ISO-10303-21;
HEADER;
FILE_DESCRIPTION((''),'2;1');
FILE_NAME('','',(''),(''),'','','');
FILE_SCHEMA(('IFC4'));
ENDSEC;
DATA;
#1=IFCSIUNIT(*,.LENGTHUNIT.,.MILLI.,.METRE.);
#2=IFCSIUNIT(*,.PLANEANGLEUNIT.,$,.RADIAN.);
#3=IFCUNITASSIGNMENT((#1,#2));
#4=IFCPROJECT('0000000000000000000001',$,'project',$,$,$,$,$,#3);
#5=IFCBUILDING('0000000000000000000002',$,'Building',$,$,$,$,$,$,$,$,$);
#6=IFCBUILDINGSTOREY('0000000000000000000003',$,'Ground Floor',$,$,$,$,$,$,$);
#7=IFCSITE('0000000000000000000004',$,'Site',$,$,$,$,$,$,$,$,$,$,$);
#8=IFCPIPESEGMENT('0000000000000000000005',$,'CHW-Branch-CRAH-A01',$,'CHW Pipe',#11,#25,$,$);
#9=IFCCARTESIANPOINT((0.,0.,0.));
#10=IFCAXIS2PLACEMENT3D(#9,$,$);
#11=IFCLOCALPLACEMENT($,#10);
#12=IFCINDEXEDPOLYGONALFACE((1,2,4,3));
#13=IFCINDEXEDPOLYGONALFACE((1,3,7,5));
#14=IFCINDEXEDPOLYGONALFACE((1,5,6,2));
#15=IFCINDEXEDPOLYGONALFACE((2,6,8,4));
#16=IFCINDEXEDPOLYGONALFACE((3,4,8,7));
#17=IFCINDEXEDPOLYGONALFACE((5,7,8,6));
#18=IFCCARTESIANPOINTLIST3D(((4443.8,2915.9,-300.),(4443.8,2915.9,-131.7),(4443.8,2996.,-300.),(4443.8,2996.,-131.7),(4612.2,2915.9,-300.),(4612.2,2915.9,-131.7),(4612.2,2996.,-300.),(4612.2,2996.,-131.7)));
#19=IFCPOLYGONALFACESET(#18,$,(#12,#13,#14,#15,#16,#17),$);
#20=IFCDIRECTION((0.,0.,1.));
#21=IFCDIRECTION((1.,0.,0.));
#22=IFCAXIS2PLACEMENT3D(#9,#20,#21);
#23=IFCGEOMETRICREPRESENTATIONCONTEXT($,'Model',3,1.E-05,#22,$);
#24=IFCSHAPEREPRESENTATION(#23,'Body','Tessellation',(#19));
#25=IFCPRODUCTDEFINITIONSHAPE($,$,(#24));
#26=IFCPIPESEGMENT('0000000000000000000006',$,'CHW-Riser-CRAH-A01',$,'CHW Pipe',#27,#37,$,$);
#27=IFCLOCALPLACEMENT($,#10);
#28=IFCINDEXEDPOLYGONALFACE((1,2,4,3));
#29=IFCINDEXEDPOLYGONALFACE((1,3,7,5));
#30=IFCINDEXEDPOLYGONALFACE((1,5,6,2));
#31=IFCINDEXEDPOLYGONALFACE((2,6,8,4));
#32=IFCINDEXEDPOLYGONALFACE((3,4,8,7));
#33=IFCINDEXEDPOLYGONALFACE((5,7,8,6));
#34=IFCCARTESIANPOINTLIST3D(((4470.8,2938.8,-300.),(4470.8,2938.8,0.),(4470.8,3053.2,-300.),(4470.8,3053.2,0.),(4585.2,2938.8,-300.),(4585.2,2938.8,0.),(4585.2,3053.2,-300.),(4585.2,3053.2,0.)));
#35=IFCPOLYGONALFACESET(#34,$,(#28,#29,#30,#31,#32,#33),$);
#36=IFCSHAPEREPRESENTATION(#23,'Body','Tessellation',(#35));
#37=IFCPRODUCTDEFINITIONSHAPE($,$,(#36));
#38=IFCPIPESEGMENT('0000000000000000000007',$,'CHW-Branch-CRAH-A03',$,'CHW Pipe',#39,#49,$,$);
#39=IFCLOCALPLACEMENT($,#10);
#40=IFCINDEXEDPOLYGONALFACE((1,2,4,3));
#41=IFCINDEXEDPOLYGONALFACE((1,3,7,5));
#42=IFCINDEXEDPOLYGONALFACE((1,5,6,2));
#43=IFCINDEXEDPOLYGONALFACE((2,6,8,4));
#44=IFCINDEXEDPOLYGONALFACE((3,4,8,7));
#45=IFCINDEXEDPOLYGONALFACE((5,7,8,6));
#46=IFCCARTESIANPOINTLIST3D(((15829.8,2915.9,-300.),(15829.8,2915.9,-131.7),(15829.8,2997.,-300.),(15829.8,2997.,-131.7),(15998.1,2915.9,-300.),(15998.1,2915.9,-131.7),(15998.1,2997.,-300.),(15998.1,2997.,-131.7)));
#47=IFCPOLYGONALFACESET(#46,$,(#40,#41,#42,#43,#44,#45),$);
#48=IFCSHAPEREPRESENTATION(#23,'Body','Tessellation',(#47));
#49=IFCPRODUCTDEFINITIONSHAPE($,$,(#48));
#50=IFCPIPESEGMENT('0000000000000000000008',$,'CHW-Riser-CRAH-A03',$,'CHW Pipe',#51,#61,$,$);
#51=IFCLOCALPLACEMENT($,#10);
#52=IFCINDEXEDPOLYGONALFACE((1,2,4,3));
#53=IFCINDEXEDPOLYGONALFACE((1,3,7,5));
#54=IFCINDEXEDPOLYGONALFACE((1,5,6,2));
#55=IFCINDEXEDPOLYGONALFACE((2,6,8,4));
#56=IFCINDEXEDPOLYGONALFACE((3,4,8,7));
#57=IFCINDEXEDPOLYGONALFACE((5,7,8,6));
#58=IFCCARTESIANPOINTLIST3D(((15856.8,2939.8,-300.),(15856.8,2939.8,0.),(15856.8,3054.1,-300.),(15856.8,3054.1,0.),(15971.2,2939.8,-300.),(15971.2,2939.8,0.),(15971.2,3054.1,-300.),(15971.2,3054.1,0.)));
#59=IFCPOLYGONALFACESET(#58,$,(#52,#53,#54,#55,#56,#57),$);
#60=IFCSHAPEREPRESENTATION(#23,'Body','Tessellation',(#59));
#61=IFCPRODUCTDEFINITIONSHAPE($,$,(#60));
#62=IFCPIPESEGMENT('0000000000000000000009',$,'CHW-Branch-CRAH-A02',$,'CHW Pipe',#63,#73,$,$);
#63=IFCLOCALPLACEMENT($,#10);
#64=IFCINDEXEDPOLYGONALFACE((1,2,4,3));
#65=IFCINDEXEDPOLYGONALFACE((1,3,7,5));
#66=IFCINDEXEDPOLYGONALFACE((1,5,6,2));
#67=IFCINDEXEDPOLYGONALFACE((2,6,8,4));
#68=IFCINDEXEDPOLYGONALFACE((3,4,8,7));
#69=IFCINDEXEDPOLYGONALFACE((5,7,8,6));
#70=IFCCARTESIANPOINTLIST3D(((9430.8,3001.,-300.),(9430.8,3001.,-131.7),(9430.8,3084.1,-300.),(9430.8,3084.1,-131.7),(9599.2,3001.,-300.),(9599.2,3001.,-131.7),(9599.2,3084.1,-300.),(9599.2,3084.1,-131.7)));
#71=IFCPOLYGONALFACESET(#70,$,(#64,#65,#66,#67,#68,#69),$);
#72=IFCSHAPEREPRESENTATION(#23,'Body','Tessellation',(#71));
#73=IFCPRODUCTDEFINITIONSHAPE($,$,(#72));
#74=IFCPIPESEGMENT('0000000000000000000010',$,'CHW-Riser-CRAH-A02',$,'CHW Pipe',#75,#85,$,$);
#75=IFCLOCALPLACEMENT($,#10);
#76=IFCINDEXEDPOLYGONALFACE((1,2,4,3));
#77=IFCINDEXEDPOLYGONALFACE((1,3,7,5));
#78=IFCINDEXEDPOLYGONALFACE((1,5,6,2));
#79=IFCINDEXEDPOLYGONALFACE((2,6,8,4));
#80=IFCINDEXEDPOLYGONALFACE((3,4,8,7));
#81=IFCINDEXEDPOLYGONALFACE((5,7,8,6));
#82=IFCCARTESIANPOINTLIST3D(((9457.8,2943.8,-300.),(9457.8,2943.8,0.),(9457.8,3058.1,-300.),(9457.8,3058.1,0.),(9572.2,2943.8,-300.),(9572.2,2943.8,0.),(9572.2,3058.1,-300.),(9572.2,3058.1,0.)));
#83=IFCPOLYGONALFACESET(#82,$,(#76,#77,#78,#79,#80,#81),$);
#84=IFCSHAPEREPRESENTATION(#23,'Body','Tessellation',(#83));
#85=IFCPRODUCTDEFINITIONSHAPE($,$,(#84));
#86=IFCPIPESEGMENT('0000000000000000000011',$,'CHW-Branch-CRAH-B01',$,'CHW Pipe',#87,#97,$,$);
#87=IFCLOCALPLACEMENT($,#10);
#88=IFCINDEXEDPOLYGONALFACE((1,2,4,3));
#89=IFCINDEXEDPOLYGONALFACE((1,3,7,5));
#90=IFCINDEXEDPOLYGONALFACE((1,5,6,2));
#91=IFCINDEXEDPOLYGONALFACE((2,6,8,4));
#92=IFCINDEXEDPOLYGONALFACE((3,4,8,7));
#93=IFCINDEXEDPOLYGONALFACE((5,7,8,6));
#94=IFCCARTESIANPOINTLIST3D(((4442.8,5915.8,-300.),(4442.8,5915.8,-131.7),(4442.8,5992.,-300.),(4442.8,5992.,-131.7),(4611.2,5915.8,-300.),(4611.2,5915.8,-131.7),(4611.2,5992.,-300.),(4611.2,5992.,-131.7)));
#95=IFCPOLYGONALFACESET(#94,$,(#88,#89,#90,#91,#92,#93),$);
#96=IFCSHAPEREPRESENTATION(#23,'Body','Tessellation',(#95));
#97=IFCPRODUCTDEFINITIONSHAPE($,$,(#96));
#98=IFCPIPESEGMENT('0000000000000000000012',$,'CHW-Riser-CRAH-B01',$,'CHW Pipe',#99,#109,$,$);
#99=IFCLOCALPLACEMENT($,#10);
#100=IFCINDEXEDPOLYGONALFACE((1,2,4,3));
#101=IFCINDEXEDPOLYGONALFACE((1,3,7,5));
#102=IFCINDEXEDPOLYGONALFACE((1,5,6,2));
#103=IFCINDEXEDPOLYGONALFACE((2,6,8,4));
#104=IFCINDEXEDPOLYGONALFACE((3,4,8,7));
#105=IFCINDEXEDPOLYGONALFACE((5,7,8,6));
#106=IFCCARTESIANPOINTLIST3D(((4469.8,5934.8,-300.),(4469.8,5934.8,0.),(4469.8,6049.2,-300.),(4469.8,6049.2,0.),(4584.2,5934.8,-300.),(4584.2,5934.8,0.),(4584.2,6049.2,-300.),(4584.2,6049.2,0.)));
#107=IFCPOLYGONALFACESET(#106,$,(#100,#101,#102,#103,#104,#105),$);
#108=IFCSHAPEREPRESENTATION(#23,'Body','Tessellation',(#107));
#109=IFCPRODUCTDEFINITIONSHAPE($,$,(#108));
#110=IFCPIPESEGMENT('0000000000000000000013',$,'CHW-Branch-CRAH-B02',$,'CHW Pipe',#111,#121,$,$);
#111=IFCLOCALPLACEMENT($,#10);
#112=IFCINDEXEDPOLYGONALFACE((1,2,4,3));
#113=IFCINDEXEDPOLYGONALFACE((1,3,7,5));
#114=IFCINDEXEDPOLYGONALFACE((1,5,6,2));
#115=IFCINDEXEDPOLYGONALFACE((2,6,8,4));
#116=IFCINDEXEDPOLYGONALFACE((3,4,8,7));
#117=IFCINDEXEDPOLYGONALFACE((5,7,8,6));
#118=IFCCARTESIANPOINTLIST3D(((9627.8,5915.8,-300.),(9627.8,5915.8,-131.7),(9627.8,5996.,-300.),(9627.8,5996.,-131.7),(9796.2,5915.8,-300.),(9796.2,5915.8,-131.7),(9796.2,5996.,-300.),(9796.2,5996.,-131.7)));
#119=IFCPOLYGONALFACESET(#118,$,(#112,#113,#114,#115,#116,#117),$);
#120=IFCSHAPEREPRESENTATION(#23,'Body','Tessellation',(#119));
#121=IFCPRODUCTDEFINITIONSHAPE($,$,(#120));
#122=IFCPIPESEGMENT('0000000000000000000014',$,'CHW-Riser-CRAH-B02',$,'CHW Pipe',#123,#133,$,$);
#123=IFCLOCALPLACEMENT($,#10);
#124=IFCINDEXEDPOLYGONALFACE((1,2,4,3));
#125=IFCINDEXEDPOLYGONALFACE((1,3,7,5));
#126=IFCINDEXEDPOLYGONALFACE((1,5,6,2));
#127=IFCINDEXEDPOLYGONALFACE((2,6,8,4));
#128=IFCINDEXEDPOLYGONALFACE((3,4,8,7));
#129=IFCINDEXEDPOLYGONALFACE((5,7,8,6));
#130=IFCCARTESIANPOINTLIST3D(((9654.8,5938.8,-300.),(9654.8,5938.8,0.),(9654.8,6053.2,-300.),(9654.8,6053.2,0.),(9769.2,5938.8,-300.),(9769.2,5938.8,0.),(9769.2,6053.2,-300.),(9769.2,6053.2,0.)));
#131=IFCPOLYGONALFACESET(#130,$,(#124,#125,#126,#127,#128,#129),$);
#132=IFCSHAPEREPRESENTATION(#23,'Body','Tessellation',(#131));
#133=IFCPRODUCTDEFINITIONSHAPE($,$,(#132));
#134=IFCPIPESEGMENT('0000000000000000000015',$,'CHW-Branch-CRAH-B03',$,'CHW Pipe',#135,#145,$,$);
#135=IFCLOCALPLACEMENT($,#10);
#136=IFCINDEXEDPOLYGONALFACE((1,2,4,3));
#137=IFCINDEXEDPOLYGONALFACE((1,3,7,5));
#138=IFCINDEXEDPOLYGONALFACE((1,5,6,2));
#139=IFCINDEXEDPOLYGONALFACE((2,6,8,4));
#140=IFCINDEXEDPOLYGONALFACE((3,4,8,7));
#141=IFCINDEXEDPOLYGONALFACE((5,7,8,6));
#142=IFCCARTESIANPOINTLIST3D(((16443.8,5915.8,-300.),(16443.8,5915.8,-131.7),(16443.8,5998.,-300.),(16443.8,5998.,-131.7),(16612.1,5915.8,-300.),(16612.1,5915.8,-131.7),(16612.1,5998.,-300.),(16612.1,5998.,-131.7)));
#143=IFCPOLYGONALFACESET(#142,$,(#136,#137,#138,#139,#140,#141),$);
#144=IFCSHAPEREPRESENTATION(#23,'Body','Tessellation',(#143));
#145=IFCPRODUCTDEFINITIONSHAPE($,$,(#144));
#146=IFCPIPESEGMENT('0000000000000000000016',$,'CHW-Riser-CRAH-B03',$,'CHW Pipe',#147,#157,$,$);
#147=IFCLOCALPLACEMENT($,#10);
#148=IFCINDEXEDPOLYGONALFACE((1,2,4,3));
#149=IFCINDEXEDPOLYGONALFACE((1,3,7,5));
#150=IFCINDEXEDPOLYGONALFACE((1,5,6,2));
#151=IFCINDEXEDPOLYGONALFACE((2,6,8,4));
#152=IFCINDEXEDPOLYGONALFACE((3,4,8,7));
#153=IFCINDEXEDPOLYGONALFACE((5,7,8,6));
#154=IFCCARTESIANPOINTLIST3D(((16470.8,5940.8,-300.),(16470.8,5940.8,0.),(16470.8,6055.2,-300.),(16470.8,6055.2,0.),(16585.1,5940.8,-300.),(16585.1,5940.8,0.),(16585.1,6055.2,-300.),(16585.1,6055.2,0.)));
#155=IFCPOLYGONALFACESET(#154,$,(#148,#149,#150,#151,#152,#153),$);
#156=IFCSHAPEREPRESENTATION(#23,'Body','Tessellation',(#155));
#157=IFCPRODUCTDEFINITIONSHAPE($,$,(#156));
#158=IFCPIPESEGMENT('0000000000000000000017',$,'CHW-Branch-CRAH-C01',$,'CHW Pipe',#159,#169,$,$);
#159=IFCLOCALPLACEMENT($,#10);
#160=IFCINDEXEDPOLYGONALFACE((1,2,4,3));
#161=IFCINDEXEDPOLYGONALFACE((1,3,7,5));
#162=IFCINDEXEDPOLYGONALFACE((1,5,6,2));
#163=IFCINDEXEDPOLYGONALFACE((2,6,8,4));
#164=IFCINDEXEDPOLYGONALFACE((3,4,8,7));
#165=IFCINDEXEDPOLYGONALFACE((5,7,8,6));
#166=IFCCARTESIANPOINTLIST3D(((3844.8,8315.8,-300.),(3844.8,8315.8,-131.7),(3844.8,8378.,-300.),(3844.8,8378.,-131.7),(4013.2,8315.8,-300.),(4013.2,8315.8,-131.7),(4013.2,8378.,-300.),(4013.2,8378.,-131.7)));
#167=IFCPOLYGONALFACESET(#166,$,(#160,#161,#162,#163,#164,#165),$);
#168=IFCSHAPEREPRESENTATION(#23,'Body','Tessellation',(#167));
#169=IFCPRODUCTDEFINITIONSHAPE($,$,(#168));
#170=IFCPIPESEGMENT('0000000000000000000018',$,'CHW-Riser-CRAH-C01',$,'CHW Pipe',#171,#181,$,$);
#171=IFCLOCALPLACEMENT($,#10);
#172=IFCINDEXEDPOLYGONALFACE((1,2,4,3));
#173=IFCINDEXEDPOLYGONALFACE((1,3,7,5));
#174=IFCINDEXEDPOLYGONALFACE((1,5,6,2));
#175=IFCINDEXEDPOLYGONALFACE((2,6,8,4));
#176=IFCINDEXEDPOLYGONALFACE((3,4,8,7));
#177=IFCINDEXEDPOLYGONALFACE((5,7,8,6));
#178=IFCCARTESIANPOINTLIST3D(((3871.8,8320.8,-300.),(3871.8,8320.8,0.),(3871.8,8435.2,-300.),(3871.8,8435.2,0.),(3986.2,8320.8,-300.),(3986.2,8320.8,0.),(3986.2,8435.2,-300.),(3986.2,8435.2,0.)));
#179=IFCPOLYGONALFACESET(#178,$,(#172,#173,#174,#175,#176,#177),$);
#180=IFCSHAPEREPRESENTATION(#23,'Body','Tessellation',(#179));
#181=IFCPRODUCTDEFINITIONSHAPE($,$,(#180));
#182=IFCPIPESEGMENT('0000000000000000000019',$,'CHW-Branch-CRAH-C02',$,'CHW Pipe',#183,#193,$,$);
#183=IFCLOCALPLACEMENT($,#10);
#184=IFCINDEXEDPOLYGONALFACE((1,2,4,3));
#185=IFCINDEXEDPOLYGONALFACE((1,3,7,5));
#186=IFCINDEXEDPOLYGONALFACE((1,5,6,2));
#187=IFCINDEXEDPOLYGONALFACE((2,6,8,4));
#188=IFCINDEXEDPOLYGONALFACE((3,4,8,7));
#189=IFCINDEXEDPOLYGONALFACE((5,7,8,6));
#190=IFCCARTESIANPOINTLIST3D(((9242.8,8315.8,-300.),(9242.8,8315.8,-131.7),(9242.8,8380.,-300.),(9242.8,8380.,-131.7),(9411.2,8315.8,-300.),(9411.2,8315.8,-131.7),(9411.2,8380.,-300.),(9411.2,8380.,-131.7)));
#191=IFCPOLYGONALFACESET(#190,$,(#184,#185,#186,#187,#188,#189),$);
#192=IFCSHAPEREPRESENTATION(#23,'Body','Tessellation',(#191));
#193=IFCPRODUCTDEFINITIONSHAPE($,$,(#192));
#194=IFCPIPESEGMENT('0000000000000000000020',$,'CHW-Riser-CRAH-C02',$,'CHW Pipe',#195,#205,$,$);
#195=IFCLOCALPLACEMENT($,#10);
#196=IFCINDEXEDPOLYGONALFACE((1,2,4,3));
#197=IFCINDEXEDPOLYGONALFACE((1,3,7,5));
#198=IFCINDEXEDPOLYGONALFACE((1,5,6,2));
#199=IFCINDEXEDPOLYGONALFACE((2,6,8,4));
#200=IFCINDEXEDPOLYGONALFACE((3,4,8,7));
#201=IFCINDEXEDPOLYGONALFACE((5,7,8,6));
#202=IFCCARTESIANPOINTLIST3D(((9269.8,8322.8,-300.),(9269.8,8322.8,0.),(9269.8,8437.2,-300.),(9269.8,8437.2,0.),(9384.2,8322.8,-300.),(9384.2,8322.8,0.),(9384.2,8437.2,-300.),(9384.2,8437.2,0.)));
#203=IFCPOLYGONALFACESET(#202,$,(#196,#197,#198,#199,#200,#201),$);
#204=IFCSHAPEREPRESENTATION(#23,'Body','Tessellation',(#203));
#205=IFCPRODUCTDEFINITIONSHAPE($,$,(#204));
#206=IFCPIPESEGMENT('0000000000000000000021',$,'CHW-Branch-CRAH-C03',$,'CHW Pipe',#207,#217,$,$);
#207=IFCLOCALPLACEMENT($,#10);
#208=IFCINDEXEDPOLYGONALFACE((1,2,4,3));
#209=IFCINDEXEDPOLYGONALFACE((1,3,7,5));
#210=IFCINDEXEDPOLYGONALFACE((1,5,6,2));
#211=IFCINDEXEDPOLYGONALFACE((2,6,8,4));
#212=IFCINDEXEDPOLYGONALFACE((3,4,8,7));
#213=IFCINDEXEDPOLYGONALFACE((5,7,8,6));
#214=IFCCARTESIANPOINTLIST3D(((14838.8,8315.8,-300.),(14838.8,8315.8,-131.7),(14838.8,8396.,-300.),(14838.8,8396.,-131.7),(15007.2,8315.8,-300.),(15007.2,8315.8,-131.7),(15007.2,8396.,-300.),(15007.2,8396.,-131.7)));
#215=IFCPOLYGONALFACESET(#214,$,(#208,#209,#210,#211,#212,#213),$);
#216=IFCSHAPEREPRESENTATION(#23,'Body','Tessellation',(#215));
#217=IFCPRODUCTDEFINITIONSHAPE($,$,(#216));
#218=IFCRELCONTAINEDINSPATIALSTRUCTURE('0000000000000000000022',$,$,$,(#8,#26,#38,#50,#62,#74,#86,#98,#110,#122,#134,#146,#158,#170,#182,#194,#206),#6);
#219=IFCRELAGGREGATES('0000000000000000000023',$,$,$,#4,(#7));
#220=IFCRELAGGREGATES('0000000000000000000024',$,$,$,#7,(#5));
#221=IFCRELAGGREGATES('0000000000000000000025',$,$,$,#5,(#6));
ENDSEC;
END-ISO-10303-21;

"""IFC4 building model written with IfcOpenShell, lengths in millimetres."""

from ifc_helpers import new_model, si_unit, frame, origin_with_axes, place, context, project, spatial, rectangle, extrude, element, save


model = new_model("IFC4")

# Units and contexts
model_context = context("Model", 3, precision=1e-05, world=origin_with_axes())
ifc_project = project(units=[si_unit("LENGTHUNIT", "METRE", prefix="MILLI"), si_unit("PLANEANGLEUNIT", "RADIAN")])

# Site, building, storey
site = spatial("IfcSite", under=ifc_project, Name="Site")
building = spatial("IfcBuilding", under=site, Name="Building")
storey = spatial("IfcBuildingStorey", under=building, Name="Ground Floor")

# Pipe segments
pipe_segment_1_placement = place(None, origin_with_axes())
element("IfcPipeSegment", 1, at=pipe_segment_1_placement, inside=storey, Name="CHW-Branch-CRAH-A01", ObjectType="CHW Pipe", context=model_context, shape_type="SweptSolid", body=[
    extrude(rectangle(XDim=168.3, YDim=80.2), frame((4528.0, 2955.9, -300.0), z_axis=(0.0, 0.0, 1.0), x_axis=(1.0, 0.0, 0.0)), (0.0, 0.0, 1.0), 168.3),
])
pipe_segment_2_placement = place(None, origin_with_axes())
element("IfcPipeSegment", 2, at=pipe_segment_2_placement, inside=storey, Name="CHW-Riser-CRAH-A01", ObjectType="CHW Pipe", context=model_context, shape_type="SweptSolid", body=[
    extrude(rectangle(XDim=114.3, YDim=114.3), frame((4528.0, 2996.0, -300.0), z_axis=(0.0, 0.0, 1.0), x_axis=(1.0, 0.0, 0.0)), (0.0, 0.0, 1.0), 300.0),
])
pipe_segment_3_placement = place(None, origin_with_axes())
element("IfcPipeSegment", 3, at=pipe_segment_3_placement, inside=storey, Name="CHW-Branch-CRAH-A03", ObjectType="CHW Pipe", context=model_context, shape_type="SweptSolid", body=[
    extrude(rectangle(XDim=168.3, YDim=81.2), frame((15914.0, 2956.4, -300.0), z_axis=(0.0, 0.0, 1.0), x_axis=(1.0, 0.0, 0.0)), (0.0, 0.0, 1.0), 168.3),
])
pipe_segment_4_placement = place(None, origin_with_axes())
element("IfcPipeSegment", 4, at=pipe_segment_4_placement, inside=storey, Name="CHW-Riser-CRAH-A03", ObjectType="CHW Pipe", context=model_context, shape_type="SweptSolid", body=[
    extrude(rectangle(XDim=114.3, YDim=114.3), frame((15914.0, 2997.0, -300.0), z_axis=(0.0, 0.0, 1.0), x_axis=(1.0, 0.0, 0.0)), (0.0, 0.0, 1.0), 300.0),
])
pipe_segment_5_placement = place(None, origin_with_axes())
element("IfcPipeSegment", 5, at=pipe_segment_5_placement, inside=storey, Name="CHW-Branch-CRAH-A02", ObjectType="CHW Pipe", context=model_context, shape_type="SweptSolid", body=[
    extrude(rectangle(XDim=168.3, YDim=83.2), frame((9515.0, 3042.6, -300.0), z_axis=(0.0, 0.0, 1.0), x_axis=(1.0, 0.0, 0.0)), (0.0, 0.0, 1.0), 168.3),
])
pipe_segment_6_placement = place(None, origin_with_axes())
element("IfcPipeSegment", 6, at=pipe_segment_6_placement, inside=storey, Name="CHW-Riser-CRAH-A02", ObjectType="CHW Pipe", context=model_context, shape_type="SweptSolid", body=[
    extrude(rectangle(XDim=114.3, YDim=114.3), frame((9515.0, 3001.0, -300.0), z_axis=(0.0, 0.0, 1.0), x_axis=(1.0, 0.0, 0.0)), (0.0, 0.0, 1.0), 300.0),
])
pipe_segment_7_placement = place(None, origin_with_axes())
element("IfcPipeSegment", 7, at=pipe_segment_7_placement, inside=storey, Name="CHW-Branch-CRAH-B01", ObjectType="CHW Pipe", context=model_context, shape_type="SweptSolid", body=[
    extrude(rectangle(XDim=168.3, YDim=76.1), frame((4527.0, 5953.9, -300.0), z_axis=(0.0, 0.0, 1.0), x_axis=(1.0, 0.0, 0.0)), (0.0, 0.0, 1.0), 168.3),
])
pipe_segment_8_placement = place(None, origin_with_axes())
element("IfcPipeSegment", 8, at=pipe_segment_8_placement, inside=storey, Name="CHW-Riser-CRAH-B01", ObjectType="CHW Pipe", context=model_context, shape_type="SweptSolid", body=[
    extrude(rectangle(XDim=114.3, YDim=114.3), frame((4527.0, 5992.0, -300.0), z_axis=(0.0, 0.0, 1.0), x_axis=(1.0, 0.0, 0.0)), (0.0, 0.0, 1.0), 300.0),
])
pipe_segment_9_placement = place(None, origin_with_axes())
element("IfcPipeSegment", 9, at=pipe_segment_9_placement, inside=storey, Name="CHW-Branch-CRAH-B02", ObjectType="CHW Pipe", context=model_context, shape_type="SweptSolid", body=[
    extrude(rectangle(XDim=168.3, YDim=80.1), frame((9712.0, 5955.9, -300.0), z_axis=(0.0, 0.0, 1.0), x_axis=(1.0, 0.0, 0.0)), (0.0, 0.0, 1.0), 168.3),
])
pipe_segment_10_placement = place(None, origin_with_axes())
element("IfcPipeSegment", 10, at=pipe_segment_10_placement, inside=storey, Name="CHW-Riser-CRAH-B02", ObjectType="CHW Pipe", context=model_context, shape_type="SweptSolid", body=[
    extrude(rectangle(XDim=114.3, YDim=114.3), frame((9712.0, 5996.0, -300.0), z_axis=(0.0, 0.0, 1.0), x_axis=(1.0, 0.0, 0.0)), (0.0, 0.0, 1.0), 300.0),
])
pipe_segment_11_placement = place(None, origin_with_axes())
element("IfcPipeSegment", 11, at=pipe_segment_11_placement, inside=storey, Name="CHW-Branch-CRAH-B03", ObjectType="CHW Pipe", context=model_context, shape_type="SweptSolid", body=[
    extrude(rectangle(XDim=168.3, YDim=82.1), frame((16528.0, 5956.9, -300.0), z_axis=(0.0, 0.0, 1.0), x_axis=(1.0, 0.0, 0.0)), (0.0, 0.0, 1.0), 168.3),
])
pipe_segment_12_placement = place(None, origin_with_axes())
element("IfcPipeSegment", 12, at=pipe_segment_12_placement, inside=storey, Name="CHW-Riser-CRAH-B03", ObjectType="CHW Pipe", context=model_context, shape_type="SweptSolid", body=[
    extrude(rectangle(XDim=114.3, YDim=114.3), frame((16528.0, 5998.0, -300.0), z_axis=(0.0, 0.0, 1.0), x_axis=(1.0, 0.0, 0.0)), (0.0, 0.0, 1.0), 300.0),
])
pipe_segment_13_placement = place(None, origin_with_axes())
element("IfcPipeSegment", 13, at=pipe_segment_13_placement, inside=storey, Name="CHW-Branch-CRAH-C01", ObjectType="CHW Pipe", context=model_context, shape_type="SweptSolid", body=[
    extrude(rectangle(XDim=168.3, YDim=62.1), frame((3929.0, 8346.9, -300.0), z_axis=(0.0, 0.0, 1.0), x_axis=(1.0, 0.0, 0.0)), (0.0, 0.0, 1.0), 168.3),
])
pipe_segment_14_placement = place(None, origin_with_axes())
element("IfcPipeSegment", 14, at=pipe_segment_14_placement, inside=storey, Name="CHW-Riser-CRAH-C01", ObjectType="CHW Pipe", context=model_context, shape_type="SweptSolid", body=[
    extrude(rectangle(XDim=114.3, YDim=114.3), frame((3929.0, 8378.0, -300.0), z_axis=(0.0, 0.0, 1.0), x_axis=(1.0, 0.0, 0.0)), (0.0, 0.0, 1.0), 300.0),
])
pipe_segment_15_placement = place(None, origin_with_axes())
element("IfcPipeSegment", 15, at=pipe_segment_15_placement, inside=storey, Name="CHW-Branch-CRAH-C02", ObjectType="CHW Pipe", context=model_context, shape_type="SweptSolid", body=[
    extrude(rectangle(XDim=168.3, YDim=64.1), frame((9327.0, 8347.9, -300.0), z_axis=(0.0, 0.0, 1.0), x_axis=(1.0, 0.0, 0.0)), (0.0, 0.0, 1.0), 168.3),
])
pipe_segment_16_placement = place(None, origin_with_axes())
element("IfcPipeSegment", 16, at=pipe_segment_16_placement, inside=storey, Name="CHW-Riser-CRAH-C02", ObjectType="CHW Pipe", context=model_context, shape_type="SweptSolid", body=[
    extrude(rectangle(XDim=114.3, YDim=114.3), frame((9327.0, 8380.0, -300.0), z_axis=(0.0, 0.0, 1.0), x_axis=(1.0, 0.0, 0.0)), (0.0, 0.0, 1.0), 300.0),
])
pipe_segment_17_placement = place(None, origin_with_axes())
element("IfcPipeSegment", 17, at=pipe_segment_17_placement, inside=storey, Name="CHW-Branch-CRAH-C03", ObjectType="CHW Pipe", context=model_context, shape_type="SweptSolid", body=[
    extrude(rectangle(XDim=168.3, YDim=80.1), frame((14923.0, 8355.9, -300.0), z_axis=(0.0, 0.0, 1.0), x_axis=(1.0, 0.0, 0.0)), (0.0, 0.0, 1.0), 168.3),
])

save(model, "model.ifc")
